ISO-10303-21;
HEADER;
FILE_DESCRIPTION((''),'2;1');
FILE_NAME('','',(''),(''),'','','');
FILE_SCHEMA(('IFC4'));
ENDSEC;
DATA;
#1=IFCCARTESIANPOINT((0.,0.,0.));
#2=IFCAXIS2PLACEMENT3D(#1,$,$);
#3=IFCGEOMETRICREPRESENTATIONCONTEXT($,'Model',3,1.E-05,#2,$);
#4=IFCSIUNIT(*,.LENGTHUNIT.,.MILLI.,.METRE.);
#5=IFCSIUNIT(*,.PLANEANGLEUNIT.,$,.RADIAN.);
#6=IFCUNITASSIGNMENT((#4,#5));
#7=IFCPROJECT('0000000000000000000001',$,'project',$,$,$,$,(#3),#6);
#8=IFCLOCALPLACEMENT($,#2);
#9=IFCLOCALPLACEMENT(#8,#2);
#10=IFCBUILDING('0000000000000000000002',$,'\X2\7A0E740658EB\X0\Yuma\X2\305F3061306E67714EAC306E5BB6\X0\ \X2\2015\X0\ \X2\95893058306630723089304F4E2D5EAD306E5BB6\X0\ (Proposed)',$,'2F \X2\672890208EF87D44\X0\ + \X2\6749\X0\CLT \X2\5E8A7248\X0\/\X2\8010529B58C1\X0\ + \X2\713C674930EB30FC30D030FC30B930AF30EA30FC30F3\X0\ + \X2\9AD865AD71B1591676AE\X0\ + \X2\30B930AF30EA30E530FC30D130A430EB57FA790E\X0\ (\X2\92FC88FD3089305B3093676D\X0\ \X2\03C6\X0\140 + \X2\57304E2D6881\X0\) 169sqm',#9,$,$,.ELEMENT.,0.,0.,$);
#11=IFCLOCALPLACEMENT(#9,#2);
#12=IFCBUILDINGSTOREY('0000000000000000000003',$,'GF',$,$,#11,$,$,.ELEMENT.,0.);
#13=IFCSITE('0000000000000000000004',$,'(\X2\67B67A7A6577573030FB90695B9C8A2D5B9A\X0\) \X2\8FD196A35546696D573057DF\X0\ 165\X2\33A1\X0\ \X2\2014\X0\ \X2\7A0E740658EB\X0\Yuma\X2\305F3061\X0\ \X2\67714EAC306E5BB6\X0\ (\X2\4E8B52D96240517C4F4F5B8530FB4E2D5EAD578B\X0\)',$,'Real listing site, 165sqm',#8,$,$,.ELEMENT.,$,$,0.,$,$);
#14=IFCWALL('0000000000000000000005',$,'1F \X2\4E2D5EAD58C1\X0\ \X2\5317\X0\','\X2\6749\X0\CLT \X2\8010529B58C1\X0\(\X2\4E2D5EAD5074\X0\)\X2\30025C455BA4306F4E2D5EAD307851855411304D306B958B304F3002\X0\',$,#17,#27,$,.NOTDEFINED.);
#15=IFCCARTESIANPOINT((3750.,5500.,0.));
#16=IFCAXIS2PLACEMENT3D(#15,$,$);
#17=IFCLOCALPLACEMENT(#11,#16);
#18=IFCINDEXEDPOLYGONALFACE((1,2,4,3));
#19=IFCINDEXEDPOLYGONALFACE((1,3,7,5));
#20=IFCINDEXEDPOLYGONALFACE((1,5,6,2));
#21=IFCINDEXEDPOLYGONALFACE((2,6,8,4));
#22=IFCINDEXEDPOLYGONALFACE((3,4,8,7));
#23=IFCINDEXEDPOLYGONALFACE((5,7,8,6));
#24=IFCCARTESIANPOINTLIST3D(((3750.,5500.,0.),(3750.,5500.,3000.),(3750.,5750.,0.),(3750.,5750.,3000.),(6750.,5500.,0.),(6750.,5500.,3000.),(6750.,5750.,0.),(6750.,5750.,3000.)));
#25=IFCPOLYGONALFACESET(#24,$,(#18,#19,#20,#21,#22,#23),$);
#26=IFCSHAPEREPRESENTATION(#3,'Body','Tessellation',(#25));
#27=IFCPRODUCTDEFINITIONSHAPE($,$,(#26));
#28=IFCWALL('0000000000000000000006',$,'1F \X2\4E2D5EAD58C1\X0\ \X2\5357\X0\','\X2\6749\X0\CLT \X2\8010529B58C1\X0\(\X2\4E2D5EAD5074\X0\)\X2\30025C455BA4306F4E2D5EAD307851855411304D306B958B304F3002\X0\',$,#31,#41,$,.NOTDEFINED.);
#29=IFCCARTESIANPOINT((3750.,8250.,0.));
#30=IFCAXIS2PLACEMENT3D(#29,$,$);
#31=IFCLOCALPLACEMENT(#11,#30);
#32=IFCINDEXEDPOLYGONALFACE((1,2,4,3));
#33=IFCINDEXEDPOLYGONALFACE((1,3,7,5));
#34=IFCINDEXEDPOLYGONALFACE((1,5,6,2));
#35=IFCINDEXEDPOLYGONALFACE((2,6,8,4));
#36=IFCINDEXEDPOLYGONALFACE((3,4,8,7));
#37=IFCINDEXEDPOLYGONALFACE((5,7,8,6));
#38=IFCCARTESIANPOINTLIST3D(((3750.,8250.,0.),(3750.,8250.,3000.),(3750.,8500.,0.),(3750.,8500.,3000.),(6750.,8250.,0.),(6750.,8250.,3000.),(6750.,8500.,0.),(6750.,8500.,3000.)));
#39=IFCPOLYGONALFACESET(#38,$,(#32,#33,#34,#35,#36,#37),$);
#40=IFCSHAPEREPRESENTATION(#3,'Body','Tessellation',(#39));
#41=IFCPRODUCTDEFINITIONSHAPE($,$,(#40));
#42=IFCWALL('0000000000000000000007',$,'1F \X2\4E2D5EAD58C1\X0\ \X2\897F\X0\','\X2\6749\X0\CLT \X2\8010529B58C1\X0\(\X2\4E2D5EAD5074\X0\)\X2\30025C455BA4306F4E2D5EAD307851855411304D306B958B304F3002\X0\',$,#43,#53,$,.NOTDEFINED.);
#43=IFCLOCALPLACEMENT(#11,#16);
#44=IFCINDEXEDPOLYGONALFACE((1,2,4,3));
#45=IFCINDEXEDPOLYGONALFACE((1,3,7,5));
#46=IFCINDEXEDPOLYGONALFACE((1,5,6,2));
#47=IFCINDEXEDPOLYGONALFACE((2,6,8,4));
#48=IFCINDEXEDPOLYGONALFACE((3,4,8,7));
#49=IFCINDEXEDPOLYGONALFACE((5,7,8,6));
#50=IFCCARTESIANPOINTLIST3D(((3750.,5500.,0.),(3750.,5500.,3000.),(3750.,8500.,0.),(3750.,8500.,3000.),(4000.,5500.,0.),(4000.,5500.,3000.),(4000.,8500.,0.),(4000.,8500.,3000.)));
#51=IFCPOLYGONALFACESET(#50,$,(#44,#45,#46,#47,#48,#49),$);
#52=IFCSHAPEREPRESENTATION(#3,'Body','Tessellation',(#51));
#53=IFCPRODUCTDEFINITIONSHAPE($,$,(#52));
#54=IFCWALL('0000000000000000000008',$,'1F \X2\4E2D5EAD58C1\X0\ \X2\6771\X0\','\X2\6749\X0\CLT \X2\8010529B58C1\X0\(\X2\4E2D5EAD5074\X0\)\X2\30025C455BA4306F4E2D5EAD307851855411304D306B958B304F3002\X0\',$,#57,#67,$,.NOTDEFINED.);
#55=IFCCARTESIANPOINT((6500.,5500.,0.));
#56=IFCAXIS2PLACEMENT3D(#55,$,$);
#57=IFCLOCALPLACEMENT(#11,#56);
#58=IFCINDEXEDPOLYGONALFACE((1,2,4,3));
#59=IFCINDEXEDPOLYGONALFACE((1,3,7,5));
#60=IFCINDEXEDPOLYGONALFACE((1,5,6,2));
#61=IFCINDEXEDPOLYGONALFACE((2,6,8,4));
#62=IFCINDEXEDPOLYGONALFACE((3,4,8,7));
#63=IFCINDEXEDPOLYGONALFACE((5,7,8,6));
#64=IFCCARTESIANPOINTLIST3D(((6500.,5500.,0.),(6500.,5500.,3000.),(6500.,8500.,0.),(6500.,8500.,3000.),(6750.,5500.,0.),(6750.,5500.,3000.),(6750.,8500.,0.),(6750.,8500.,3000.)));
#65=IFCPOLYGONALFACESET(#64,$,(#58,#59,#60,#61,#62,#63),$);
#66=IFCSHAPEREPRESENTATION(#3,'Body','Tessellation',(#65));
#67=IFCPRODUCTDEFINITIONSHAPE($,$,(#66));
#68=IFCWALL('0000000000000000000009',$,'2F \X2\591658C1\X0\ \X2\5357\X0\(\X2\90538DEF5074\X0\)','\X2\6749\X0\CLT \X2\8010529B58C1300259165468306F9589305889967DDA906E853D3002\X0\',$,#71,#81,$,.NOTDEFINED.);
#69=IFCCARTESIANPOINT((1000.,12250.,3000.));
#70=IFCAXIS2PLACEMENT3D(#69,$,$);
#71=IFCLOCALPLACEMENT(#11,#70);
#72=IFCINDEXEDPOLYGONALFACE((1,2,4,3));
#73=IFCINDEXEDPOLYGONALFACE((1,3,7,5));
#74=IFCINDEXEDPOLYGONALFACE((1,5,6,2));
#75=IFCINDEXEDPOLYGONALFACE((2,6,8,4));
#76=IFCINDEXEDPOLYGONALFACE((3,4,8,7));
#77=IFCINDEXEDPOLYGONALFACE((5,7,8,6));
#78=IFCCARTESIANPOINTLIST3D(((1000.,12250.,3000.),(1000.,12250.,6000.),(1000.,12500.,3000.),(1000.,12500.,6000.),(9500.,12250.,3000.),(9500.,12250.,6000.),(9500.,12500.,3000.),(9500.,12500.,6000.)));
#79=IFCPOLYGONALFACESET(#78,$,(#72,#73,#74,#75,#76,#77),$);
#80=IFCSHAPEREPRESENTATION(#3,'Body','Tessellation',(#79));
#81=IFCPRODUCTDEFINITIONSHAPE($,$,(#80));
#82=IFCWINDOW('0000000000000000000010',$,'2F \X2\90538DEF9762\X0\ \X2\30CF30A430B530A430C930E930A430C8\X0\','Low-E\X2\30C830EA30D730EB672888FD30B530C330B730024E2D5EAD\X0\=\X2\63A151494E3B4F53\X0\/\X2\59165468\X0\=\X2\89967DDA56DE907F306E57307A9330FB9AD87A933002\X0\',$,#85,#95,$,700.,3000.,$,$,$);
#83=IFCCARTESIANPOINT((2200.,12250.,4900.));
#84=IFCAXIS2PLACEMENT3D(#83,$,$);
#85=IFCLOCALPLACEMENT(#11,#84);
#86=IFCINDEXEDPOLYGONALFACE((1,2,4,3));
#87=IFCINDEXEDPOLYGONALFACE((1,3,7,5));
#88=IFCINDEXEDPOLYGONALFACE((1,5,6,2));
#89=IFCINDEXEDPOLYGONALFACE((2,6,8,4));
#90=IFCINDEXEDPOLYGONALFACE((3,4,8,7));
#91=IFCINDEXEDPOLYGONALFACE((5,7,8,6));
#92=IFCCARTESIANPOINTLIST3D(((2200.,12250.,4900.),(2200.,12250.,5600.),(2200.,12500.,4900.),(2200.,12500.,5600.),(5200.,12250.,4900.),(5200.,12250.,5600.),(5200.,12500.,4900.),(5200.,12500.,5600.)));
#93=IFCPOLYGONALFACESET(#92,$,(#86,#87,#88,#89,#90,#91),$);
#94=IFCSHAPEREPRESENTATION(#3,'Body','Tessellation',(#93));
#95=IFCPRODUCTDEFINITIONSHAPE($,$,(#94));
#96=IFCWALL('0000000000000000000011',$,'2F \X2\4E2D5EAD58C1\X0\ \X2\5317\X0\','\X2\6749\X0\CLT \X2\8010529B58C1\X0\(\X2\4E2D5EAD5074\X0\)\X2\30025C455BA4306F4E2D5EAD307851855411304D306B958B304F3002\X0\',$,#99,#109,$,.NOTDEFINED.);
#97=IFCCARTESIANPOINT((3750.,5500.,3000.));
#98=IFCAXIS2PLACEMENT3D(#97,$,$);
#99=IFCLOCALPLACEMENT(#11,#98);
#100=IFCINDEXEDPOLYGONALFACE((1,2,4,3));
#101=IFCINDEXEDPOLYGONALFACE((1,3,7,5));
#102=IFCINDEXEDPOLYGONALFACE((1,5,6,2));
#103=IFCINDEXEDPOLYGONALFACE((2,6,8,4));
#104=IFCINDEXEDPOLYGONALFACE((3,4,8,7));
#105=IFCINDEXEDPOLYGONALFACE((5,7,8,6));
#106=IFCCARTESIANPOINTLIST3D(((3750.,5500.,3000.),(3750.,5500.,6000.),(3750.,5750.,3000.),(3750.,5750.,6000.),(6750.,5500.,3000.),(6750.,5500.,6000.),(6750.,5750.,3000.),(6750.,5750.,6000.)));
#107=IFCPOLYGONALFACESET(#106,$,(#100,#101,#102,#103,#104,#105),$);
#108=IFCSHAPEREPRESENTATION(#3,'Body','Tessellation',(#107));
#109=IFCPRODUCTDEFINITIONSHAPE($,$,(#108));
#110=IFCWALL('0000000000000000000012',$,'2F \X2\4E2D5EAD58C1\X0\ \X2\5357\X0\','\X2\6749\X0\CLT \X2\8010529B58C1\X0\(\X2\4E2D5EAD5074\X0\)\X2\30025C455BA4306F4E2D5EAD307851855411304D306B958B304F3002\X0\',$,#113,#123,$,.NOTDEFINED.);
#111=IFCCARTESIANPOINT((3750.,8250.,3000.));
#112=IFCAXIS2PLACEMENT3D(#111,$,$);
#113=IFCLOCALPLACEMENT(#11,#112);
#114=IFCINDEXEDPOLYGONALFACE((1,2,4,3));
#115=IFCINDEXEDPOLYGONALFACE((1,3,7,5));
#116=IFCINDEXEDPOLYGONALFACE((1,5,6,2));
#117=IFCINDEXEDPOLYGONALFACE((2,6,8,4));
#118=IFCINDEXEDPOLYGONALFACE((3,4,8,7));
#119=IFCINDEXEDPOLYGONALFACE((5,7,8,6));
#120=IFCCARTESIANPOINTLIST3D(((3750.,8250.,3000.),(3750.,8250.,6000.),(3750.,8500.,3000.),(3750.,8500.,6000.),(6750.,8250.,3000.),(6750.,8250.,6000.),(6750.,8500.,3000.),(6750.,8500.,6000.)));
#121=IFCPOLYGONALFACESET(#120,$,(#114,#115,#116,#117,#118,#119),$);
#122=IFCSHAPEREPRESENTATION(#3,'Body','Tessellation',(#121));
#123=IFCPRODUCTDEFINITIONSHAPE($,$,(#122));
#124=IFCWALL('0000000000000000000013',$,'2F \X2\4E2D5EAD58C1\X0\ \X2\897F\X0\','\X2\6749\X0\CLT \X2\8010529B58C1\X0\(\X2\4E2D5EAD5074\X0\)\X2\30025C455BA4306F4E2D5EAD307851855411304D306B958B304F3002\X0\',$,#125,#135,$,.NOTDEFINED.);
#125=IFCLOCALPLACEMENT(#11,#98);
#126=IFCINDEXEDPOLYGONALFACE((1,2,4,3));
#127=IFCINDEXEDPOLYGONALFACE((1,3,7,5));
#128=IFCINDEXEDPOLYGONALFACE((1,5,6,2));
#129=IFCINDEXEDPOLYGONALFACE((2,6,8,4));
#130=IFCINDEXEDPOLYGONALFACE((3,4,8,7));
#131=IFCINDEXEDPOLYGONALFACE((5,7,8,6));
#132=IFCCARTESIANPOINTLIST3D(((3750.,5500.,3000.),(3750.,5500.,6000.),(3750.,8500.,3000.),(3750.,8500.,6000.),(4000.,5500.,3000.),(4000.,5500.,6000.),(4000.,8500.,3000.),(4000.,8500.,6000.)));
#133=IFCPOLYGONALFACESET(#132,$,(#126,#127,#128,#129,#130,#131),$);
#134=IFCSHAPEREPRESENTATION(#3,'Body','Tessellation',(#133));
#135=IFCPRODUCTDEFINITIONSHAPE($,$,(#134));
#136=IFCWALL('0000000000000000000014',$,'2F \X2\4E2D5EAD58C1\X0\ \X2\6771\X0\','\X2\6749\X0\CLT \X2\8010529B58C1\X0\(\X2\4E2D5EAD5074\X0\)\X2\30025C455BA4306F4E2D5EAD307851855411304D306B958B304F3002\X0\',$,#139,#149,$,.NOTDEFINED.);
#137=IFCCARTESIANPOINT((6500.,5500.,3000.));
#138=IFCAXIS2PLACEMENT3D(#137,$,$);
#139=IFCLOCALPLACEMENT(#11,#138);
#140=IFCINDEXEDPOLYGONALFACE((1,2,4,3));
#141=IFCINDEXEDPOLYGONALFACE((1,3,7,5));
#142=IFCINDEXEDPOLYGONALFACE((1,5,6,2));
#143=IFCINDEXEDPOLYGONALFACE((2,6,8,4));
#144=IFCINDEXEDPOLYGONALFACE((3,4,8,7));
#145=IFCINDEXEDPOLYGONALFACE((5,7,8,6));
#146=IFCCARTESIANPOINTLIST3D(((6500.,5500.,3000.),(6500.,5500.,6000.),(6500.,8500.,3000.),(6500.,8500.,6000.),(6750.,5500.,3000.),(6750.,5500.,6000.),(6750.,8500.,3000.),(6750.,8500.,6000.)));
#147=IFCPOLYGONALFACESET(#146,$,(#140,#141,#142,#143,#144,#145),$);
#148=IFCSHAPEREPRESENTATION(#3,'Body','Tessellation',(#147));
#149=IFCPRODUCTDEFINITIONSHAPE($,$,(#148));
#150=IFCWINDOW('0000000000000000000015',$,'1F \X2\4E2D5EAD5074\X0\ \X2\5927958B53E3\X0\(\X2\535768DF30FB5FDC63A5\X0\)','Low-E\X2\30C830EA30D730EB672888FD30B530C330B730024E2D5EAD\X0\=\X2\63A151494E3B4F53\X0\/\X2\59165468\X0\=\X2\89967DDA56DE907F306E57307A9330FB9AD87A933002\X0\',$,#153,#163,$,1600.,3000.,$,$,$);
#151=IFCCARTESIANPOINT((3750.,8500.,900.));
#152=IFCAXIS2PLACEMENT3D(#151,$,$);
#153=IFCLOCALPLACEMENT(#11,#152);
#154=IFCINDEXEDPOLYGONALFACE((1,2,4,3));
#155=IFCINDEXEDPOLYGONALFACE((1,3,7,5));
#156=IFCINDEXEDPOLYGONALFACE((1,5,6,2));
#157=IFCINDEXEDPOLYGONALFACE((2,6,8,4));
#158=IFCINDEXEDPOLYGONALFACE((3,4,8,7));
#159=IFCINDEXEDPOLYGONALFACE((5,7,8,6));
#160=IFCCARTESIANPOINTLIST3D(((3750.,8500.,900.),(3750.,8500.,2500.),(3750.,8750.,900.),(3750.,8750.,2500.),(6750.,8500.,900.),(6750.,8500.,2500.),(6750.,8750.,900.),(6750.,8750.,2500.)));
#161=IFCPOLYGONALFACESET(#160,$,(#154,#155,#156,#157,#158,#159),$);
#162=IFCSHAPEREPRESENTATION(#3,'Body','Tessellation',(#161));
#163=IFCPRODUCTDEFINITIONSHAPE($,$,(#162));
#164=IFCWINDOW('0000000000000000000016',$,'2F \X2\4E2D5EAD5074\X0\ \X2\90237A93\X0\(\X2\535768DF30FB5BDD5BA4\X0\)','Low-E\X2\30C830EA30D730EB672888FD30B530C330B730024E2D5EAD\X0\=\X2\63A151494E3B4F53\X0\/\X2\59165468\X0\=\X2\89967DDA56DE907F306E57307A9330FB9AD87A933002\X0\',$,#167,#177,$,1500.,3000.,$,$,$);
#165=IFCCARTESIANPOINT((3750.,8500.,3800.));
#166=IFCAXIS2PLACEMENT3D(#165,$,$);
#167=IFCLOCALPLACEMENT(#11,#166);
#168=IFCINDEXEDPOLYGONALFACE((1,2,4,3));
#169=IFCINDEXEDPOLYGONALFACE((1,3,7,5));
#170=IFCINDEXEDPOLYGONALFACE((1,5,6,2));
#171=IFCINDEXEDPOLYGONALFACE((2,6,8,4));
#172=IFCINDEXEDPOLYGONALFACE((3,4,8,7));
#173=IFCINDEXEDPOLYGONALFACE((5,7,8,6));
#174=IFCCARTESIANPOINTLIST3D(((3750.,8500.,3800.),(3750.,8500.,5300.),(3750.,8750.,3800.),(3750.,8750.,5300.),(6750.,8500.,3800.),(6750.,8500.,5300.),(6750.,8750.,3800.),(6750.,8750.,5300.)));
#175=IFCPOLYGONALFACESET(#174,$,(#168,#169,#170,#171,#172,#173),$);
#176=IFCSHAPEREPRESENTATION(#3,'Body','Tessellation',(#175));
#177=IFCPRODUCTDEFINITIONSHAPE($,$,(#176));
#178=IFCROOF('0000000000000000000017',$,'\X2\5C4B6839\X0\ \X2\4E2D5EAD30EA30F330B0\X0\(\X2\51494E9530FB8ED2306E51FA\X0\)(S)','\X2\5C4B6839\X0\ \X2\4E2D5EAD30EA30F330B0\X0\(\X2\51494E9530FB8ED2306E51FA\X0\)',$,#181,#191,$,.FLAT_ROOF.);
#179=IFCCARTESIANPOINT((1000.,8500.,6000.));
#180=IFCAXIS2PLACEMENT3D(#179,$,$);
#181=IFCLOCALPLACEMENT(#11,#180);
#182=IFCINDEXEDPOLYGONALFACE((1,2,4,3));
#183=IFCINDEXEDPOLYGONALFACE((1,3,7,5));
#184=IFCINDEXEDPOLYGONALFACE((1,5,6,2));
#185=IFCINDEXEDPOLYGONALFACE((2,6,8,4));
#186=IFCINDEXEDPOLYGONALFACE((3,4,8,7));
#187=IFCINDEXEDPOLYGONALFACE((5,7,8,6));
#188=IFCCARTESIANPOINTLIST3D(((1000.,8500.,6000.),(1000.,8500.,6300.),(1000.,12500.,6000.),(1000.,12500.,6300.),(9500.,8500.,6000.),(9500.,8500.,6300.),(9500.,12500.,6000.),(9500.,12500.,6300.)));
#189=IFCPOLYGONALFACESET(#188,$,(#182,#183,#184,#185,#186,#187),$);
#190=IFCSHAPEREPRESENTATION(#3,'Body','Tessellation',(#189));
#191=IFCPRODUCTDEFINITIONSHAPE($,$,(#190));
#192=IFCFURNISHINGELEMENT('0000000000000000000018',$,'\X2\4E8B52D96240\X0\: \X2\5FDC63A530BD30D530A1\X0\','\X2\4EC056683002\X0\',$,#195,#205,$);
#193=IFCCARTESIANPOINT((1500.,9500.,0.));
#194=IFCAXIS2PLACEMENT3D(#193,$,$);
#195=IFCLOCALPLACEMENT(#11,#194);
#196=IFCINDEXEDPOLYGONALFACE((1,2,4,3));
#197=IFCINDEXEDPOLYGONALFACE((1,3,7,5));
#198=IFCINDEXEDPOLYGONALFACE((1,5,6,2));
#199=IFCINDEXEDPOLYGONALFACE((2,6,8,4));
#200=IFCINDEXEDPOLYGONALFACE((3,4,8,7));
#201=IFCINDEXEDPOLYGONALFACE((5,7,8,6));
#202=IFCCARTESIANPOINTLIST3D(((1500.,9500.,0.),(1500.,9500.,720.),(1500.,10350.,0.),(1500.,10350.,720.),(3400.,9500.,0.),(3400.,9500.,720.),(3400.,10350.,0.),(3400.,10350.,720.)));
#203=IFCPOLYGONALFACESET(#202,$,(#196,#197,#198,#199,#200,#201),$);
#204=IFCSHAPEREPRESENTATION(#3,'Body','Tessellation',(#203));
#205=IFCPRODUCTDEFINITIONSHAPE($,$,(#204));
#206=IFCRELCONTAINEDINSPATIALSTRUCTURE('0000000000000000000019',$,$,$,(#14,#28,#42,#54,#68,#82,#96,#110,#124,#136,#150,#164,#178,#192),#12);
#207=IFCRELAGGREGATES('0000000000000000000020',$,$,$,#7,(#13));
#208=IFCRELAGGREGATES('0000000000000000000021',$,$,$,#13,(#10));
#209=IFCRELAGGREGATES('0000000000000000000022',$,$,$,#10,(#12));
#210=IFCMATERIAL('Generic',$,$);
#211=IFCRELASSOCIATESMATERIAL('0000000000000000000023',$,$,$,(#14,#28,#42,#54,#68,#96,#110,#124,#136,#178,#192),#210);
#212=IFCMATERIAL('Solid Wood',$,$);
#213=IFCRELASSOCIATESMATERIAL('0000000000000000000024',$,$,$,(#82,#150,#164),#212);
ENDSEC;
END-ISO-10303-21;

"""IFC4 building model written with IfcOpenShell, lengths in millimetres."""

from ifc_helpers import new_model, si_unit, frame, frame_2d, origin, place, context, project, spatial, rectangle, extrude, material, element, fill, save


model = new_model("IFC4")

# Units and contexts
model_context = context("Model", 3, precision=1e-05, world=origin())
ifc_project = project(units=[si_unit("LENGTHUNIT", "METRE", prefix="MILLI"), si_unit("PLANEANGLEUNIT", "RADIAN")], contexts=[model_context])

# Site, building, storey
site_placement = place(None, origin())
site = spatial("IfcSite", under=ifc_project, at=site_placement, Name="(架空敷地・適宜設定) 近隣商業地域 165㎡ — 税理士Yumaたち 東京の家 (事務所兼住宅・中庭型)", ObjectType="Real listing site, 165sqm", CompositionType="ELEMENT", RefElevation=0.0)
building_placement = place(site_placement, origin())
building = spatial("IfcBuilding", under=site, at=building_placement, Name="税理士Yumaたちの東京の家 ― 閉じてひらく中庭の家 (Proposed)", ObjectType="2F 木造軸組 + 杉CLT 床版/耐力壁 + 焼杉ルーバースクリーン + 高断熱外皮 + スクリューパイル基礎 (鋼製らせん杭 φ140 + 地中梁) 169sqm", CompositionType="ELEMENT", ElevationOfRefHeight=0.0, ElevationOfTerrain=0.0)
storey_placement = place(building_placement, origin())
storey = spatial("IfcBuildingStorey", under=building, at=storey_placement, Name="GF", CompositionType="ELEMENT", Elevation=0.0)

# Shared definitions
ifc_material_1 = material(Name="Generic")

# Shared definitions
ifc_material_2 = material(Name="Solid Wood")

# Walls
wall_1_placement = place(storey_placement, frame((3750.0, 5500.0, 0.0)))
element("IfcWall", 1, at=wall_1_placement, inside=storey, material=ifc_material_1, Name="1F 中庭壁 北", Description="杉CLT 耐力壁(中庭側)。居室は中庭へ内向きに開く。", PredefinedType="NOTDEFINED", context=model_context, shape_type="SweptSolid", body=[
    extrude(rectangle(XDim=3000.0, YDim=250.0, at=frame_2d((1500.0, 125.0))), frame((3750.0, 5500.0, 0.0)), (0.0, 0.0, 1.0), 3000.0),
])
wall_2_placement = place(storey_placement, frame((3750.0, 8250.0, 0.0)))
element("IfcWall", 2, at=wall_2_placement, inside=storey, material=ifc_material_1, Name="1F 中庭壁 南", Description="杉CLT 耐力壁(中庭側)。居室は中庭へ内向きに開く。", PredefinedType="NOTDEFINED", context=model_context, shape_type="SweptSolid", body=[
    extrude(rectangle(XDim=3000.0, YDim=250.0, at=frame_2d((1500.0, 125.0))), frame((3750.0, 8250.0, 0.0)), (0.0, 0.0, 1.0), 3000.0),
])
wall_3_placement = place(storey_placement, frame((3750.0, 5500.0, 0.0)))
element("IfcWall", 3, at=wall_3_placement, inside=storey, material=ifc_material_1, Name="1F 中庭壁 西", Description="杉CLT 耐力壁(中庭側)。居室は中庭へ内向きに開く。", PredefinedType="NOTDEFINED", context=model_context, shape_type="SweptSolid", body=[
    extrude(rectangle(XDim=250.0, YDim=3000.0, at=frame_2d((125.0, 1500.0))), frame((3750.0, 5500.0, 0.0)), (0.0, 0.0, 1.0), 3000.0),
])
wall_4_placement = place(storey_placement, frame((6500.0, 5500.0, 0.0)))
element("IfcWall", 4, at=wall_4_placement, inside=storey, material=ifc_material_1, Name="1F 中庭壁 東", Description="杉CLT 耐力壁(中庭側)。居室は中庭へ内向きに開く。", PredefinedType="NOTDEFINED", context=model_context, shape_type="SweptSolid", body=[
    extrude(rectangle(XDim=250.0, YDim=3000.0, at=frame_2d((125.0, 1500.0))), frame((6500.0, 5500.0, 0.0)), (0.0, 0.0, 1.0), 3000.0),
])

# Wall, opening, window
wall_5_placement = place(storey_placement, frame((1000.0, 12250.0, 3000.0)))
wall_5 = element("IfcWall", 5, at=wall_5_placement, inside=storey, material=ifc_material_1, Name="2F 外壁 南(道路側)", Description="杉CLT 耐力壁。外周は閉じ視線遮蔽。", PredefinedType="NOTDEFINED", context=model_context, shape_type="SweptSolid", body=[
    extrude(rectangle(XDim=8500.0, YDim=250.0, at=frame_2d((4250.0, 125.0))), frame((1000.0, 12250.0, 3000.0)), (0.0, 0.0, 1.0), 3000.0),
])
opening_1_placement = place(storey_placement, frame((2200.0, 12250.0, 4900.0)))
opening_1 = element("IfcOpeningElement", 6, at=opening_1_placement, cuts=wall_5, PredefinedType="NOTDEFINED", context=model_context, shape_type="SweptSolid", body=[
    extrude(rectangle(XDim=3000.0, YDim=250.0, at=frame_2d((1500.0, 125.0))), frame((2200.0, 12250.0, 4900.0)), (0.0, 0.0, 1.0), 700.0),
])
window_1_placement = place(storey_placement, frame((2200.0, 12250.0, 4900.0)))
window_1 = element("IfcWindow", 7, at=window_1_placement, inside=storey, material=ifc_material_2, Name="2F 道路面 ハイサイドライト", Description="Low-Eトリプル木製サッシ。中庭=採光主体/外周=視線回避の地窓・高窓。", OverallHeight=700.0, OverallWidth=3000.0, context=model_context, shape_type="SweptSolid", body=[
    extrude(rectangle(XDim=3000.0, YDim=250.0, at=frame_2d((1500.0, 125.0))), frame((2200.0, 12250.0, 4900.0)), (0.0, 0.0, 1.0), 700.0),
])
fill(opening_1, window_1)

# Walls
wall_6_placement = place(storey_placement, frame((3750.0, 5500.0, 3000.0)))
element("IfcWall", 8, at=wall_6_placement, inside=storey, material=ifc_material_1, Name="2F 中庭壁 北", Description="杉CLT 耐力壁(中庭側)。居室は中庭へ内向きに開く。", PredefinedType="NOTDEFINED", context=model_context, shape_type="SweptSolid", body=[
    extrude(rectangle(XDim=3000.0, YDim=250.0, at=frame_2d((1500.0, 125.0))), frame((3750.0, 5500.0, 3000.0)), (0.0, 0.0, 1.0), 3000.0),
])
wall_7_placement = place(storey_placement, frame((3750.0, 8250.0, 3000.0)))
element("IfcWall", 9, at=wall_7_placement, inside=storey, material=ifc_material_1, Name="2F 中庭壁 南", Description="杉CLT 耐力壁(中庭側)。居室は中庭へ内向きに開く。", PredefinedType="NOTDEFINED", context=model_context, shape_type="SweptSolid", body=[
    extrude(rectangle(XDim=3000.0, YDim=250.0, at=frame_2d((1500.0, 125.0))), frame((3750.0, 8250.0, 3000.0)), (0.0, 0.0, 1.0), 3000.0),
])
wall_8_placement = place(storey_placement, frame((3750.0, 5500.0, 3000.0)))
element("IfcWall", 10, at=wall_8_placement, inside=storey, material=ifc_material_1, Name="2F 中庭壁 西", Description="杉CLT 耐力壁(中庭側)。居室は中庭へ内向きに開く。", PredefinedType="NOTDEFINED", context=model_context, shape_type="SweptSolid", body=[
    extrude(rectangle(XDim=250.0, YDim=3000.0, at=frame_2d((125.0, 1500.0))), frame((3750.0, 5500.0, 3000.0)), (0.0, 0.0, 1.0), 3000.0),
])
wall_9_placement = place(storey_placement, frame((6500.0, 5500.0, 3000.0)))
element("IfcWall", 11, at=wall_9_placement, inside=storey, material=ifc_material_1, Name="2F 中庭壁 東", Description="杉CLT 耐力壁(中庭側)。居室は中庭へ内向きに開く。", PredefinedType="NOTDEFINED", context=model_context, shape_type="SweptSolid", body=[
    extrude(rectangle(XDim=250.0, YDim=3000.0, at=frame_2d((125.0, 1500.0))), frame((6500.0, 5500.0, 3000.0)), (0.0, 0.0, 1.0), 3000.0),
])

# Windows
window_2_placement = place(storey_placement, frame((3750.0, 8500.0, 900.0)))
element("IfcWindow", 12, at=window_2_placement, inside=storey, material=ifc_material_2, Name="1F 中庭側 大開口(南棟・応接)", Description="Low-Eトリプル木製サッシ。中庭=採光主体/外周=視線回避の地窓・高窓。", OverallHeight=1600.0, OverallWidth=3000.0, context=model_context, shape_type="SweptSolid", body=[
    extrude(rectangle(XDim=3000.0, YDim=250.0, at=frame_2d((1500.0, 125.0))), frame((3750.0, 8500.0, 900.0)), (0.0, 0.0, 1.0), 1600.0),
])
window_3_placement = place(storey_placement, frame((3750.0, 8500.0, 3800.0)))
element("IfcWindow", 13, at=window_3_placement, inside=storey, material=ifc_material_2, Name="2F 中庭側 連窓(南棟・寝室)", Description="Low-Eトリプル木製サッシ。中庭=採光主体/外周=視線回避の地窓・高窓。", OverallHeight=1500.0, OverallWidth=3000.0, context=model_context, shape_type="SweptSolid", body=[
    extrude(rectangle(XDim=3000.0, YDim=250.0, at=frame_2d((1500.0, 125.0))), frame((3750.0, 8500.0, 3800.0)), (0.0, 0.0, 1.0), 1500.0),
])

# Roof
roof_placement = place(storey_placement, frame((1000.0, 8500.0, 6000.0)))
element("IfcRoof", 14, at=roof_placement, inside=storey, material=ifc_material_1, Name="屋根 中庭リング(光井・軒の出)(S)", Description="屋根 中庭リング(光井・軒の出)", PredefinedType="FLAT_ROOF", context=model_context, shape_type="SweptSolid", body=[
    extrude(rectangle(XDim=8500.0, YDim=4000.0, at=frame_2d((4250.0, 2000.0))), frame((1000.0, 8500.0, 6000.0)), (0.0, 0.0, 1.0), 300.0),
])

# Furnishing element
furnishing_1_placement = place(storey_placement, frame((1500.0, 9500.0, 0.0)))
element("IfcFurnishingElement", 15, at=furnishing_1_placement, inside=storey, material=ifc_material_1, Name="事務所: 応接ソファ", Description="什器。", context=model_context, shape_type="SweptSolid", body=[
    extrude(rectangle(XDim=1900.0, YDim=850.0, at=frame_2d((950.0, 425.0))), frame((1500.0, 9500.0, 0.0)), (0.0, 0.0, 1.0), 720.0),
])

save(model, "model.ifc")
